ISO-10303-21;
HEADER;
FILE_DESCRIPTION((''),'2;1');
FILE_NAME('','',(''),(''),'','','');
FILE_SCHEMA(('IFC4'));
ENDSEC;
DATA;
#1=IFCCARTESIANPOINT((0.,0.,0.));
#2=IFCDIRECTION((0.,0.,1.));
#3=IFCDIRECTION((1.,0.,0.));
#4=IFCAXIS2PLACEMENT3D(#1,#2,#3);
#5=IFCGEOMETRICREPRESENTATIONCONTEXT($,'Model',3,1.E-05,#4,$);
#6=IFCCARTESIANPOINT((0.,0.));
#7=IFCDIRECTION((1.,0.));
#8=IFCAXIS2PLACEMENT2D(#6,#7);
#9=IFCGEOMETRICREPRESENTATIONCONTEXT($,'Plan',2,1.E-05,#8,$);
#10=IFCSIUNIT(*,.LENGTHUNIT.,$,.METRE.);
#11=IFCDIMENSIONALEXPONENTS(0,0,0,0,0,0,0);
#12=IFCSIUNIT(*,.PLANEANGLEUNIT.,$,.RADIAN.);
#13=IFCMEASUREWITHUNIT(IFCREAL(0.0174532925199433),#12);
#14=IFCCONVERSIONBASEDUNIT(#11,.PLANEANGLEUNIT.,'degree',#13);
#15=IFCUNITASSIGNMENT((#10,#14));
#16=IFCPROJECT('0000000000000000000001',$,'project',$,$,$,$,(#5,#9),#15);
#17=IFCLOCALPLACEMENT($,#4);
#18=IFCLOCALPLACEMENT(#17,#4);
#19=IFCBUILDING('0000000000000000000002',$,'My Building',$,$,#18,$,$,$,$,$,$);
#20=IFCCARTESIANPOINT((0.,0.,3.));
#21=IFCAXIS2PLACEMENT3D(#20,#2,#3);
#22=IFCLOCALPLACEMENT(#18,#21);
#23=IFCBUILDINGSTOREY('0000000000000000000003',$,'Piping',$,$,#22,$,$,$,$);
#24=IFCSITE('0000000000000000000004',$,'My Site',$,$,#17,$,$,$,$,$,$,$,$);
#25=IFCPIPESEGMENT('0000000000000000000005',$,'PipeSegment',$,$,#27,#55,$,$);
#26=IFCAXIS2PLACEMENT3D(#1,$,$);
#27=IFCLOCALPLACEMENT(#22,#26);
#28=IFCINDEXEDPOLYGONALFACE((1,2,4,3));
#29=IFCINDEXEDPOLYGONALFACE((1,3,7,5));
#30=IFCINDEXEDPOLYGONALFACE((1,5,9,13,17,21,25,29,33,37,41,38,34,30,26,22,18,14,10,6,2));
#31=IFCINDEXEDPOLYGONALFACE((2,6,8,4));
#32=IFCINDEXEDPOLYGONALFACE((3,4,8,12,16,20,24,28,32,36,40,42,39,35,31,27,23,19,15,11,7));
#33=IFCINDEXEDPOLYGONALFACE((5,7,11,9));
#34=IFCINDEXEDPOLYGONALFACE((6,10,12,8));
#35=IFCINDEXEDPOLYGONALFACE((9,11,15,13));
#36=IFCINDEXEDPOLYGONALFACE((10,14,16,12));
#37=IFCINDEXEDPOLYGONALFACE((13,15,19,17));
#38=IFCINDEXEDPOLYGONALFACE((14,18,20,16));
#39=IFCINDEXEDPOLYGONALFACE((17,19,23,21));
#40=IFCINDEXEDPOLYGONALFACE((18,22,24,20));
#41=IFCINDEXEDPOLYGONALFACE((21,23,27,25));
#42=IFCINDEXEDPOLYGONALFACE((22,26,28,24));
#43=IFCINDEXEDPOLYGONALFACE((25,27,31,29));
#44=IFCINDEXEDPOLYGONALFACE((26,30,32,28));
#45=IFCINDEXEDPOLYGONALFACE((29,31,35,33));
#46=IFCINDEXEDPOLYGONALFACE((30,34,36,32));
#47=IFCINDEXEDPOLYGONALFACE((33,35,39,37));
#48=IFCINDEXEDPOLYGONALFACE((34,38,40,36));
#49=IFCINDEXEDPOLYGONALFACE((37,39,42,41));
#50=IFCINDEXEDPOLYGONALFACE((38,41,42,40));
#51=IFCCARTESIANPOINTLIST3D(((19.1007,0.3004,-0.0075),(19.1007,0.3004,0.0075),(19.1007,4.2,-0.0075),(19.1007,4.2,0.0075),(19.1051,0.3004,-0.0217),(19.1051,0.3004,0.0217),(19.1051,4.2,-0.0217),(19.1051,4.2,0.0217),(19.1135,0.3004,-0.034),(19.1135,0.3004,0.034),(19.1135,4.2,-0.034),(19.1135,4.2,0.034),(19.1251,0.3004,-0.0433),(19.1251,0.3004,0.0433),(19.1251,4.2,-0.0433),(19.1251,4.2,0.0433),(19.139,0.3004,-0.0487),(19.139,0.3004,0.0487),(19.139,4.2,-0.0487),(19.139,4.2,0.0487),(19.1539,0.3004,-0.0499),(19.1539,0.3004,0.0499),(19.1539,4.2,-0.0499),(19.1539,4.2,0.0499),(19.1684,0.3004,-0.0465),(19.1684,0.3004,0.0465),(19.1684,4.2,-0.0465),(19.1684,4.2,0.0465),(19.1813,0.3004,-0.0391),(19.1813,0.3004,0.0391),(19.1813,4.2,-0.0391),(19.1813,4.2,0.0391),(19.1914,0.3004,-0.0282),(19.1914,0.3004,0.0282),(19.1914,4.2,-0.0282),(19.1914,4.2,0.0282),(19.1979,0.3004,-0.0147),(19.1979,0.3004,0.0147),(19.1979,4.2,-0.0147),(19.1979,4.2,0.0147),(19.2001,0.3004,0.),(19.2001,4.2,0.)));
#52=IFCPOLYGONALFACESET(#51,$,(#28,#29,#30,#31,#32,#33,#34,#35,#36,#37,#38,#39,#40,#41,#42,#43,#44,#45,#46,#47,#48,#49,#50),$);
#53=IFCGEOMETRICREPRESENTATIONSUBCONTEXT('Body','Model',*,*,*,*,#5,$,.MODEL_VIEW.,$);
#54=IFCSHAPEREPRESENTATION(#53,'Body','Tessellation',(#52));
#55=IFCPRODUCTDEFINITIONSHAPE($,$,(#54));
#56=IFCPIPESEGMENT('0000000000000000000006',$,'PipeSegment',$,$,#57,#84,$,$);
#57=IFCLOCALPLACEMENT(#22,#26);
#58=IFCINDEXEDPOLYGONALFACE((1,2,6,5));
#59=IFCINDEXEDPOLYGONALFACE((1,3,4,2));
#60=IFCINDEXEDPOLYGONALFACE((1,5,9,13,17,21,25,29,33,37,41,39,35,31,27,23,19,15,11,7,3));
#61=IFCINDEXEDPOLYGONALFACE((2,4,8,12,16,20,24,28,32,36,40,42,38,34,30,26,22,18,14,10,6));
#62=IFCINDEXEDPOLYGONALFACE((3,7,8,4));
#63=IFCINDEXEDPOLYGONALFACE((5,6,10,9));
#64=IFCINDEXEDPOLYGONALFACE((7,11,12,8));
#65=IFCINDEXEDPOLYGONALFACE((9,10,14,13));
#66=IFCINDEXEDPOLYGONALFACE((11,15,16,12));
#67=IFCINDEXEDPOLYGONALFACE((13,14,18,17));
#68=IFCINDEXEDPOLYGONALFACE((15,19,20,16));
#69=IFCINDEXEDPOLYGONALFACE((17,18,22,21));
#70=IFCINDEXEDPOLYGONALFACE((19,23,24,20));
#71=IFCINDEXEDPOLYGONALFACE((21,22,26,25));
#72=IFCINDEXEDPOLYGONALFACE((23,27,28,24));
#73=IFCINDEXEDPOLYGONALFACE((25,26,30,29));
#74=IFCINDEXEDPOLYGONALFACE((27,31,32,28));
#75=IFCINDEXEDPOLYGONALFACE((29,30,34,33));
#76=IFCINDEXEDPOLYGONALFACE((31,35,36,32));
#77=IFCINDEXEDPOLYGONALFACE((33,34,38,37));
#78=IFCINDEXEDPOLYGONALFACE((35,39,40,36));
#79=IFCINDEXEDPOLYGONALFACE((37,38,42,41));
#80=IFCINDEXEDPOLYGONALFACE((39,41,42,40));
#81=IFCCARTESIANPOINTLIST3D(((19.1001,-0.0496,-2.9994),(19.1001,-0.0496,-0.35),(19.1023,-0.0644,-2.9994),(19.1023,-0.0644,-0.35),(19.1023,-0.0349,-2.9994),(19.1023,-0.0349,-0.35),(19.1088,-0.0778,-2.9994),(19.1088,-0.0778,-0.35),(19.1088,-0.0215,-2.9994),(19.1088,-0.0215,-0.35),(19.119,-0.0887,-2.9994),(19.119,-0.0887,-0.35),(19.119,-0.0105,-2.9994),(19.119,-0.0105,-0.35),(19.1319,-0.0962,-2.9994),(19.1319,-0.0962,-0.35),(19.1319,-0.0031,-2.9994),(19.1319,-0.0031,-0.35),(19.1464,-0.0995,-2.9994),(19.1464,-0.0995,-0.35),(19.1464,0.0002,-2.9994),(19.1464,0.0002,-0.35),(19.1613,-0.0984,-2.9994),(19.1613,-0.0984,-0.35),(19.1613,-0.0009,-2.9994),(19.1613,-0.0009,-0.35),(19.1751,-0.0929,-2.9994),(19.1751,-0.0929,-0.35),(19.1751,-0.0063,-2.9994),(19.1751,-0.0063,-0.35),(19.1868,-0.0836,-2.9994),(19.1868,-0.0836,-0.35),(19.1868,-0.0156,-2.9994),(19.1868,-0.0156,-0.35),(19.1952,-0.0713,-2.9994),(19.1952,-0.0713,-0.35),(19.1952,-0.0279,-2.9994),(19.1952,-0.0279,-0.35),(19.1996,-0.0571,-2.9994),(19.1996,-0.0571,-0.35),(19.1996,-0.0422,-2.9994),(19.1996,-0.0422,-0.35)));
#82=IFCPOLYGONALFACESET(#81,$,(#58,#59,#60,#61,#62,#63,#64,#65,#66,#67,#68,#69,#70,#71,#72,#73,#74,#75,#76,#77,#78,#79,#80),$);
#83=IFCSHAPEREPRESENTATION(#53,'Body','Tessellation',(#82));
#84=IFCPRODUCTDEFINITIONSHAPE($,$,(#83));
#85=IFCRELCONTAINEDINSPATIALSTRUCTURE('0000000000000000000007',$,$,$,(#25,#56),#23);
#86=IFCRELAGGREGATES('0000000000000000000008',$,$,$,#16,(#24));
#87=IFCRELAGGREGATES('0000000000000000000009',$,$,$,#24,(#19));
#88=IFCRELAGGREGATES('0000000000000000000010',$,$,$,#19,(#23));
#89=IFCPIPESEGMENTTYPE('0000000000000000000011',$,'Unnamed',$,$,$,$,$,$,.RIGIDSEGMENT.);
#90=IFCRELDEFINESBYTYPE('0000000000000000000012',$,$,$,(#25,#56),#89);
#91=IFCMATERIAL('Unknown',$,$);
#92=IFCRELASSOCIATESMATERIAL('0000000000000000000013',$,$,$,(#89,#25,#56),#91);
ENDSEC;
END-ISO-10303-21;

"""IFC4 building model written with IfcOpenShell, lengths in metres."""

from ifc_helpers import new_model, entity, si_unit, converted_unit, frame, origin_with_axes, origin_2d_with_axis, place, context, subcontext, project, spatial, circle, extrude, material, material_profile, profile_set, profile_usage, type_object, element, save


model = new_model("IFC4")

# Units and contexts
model_context = context("Model", 3, precision=1e-05, world=origin_with_axes())
plan_context = context("Plan", 2, precision=1e-05, world=origin_2d_with_axis())
body_context = subcontext(model_context, "Body", "Model", "MODEL_VIEW")
ifc_project = project(units=[si_unit("LENGTHUNIT", "METRE"), converted_unit("PLANEANGLEUNIT", "degree", entity("IfcReal", 0.0174532925199433), si_unit("PLANEANGLEUNIT", "RADIAN"), dimensions=[0, 0, 0, 0, 0, 0, 0])], contexts=[model_context, plan_context])

# Site, building, storey
site_placement = place(None, origin_with_axes())
site = spatial("IfcSite", under=ifc_project, at=site_placement, Name="My Site")
building_placement = place(site_placement, origin_with_axes())
building = spatial("IfcBuilding", under=site, at=building_placement, Name="My Building")
storey_placement = place(building_placement, frame((0.0, 0.0, 3.0), z_axis=(0.0, 0.0, 1.0), x_axis=(1.0, 0.0, 0.0)))
storey = spatial("IfcBuildingStorey", under=building, at=storey_placement, Name="Piping")

# Pipe segments
ifc_material = material(Name="Unknown")
ifc_material_profile = material_profile(ifc_material, circle(Radius=0.05))
ifc_profile_set = profile_set([ifc_material_profile])
pipe_segment_type = type_object("IfcPipeSegmentType", Name="Unnamed", PredefinedType="RIGIDSEGMENT", material=ifc_profile_set)
ifc_profile_usage_1 = profile_usage(ifc_profile_set, cardinal=5)
pipe_segment_1_placement = place(storey_placement, frame((19.1501, 4.2, 0.0), z_axis=(0.0, -1.0, 0.0), x_axis=(1.0, 0.0, 0.0)))
element("IfcPipeSegment", 1, at=pipe_segment_1_placement, inside=storey, type_object=pipe_segment_type, material=ifc_profile_usage_1, Name="PipeSegment", context=body_context, shape_type="SweptSolid", body=[
    extrude(circle(Radius=0.05), origin_with_axes(), (0.0, 0.0, 1.0), 3.8996),
])
ifc_profile_usage_2 = profile_usage(ifc_profile_set, cardinal=5)
pipe_segment_2_placement = place(storey_placement, frame((19.1501, -0.0496, -0.35), z_axis=(0.0, 0.0, -1.0), x_axis=(-1.0, 0.0, 0.0)))
element("IfcPipeSegment", 2, at=pipe_segment_2_placement, inside=storey, type_object=pipe_segment_type, material=ifc_profile_usage_2, Name="PipeSegment", context=body_context, shape_type="SweptSolid", body=[
    extrude(circle(Radius=0.05), origin_with_axes(), (0.0, 0.0, 1.0), 2.6494),
])

save(model, "model.ifc")
